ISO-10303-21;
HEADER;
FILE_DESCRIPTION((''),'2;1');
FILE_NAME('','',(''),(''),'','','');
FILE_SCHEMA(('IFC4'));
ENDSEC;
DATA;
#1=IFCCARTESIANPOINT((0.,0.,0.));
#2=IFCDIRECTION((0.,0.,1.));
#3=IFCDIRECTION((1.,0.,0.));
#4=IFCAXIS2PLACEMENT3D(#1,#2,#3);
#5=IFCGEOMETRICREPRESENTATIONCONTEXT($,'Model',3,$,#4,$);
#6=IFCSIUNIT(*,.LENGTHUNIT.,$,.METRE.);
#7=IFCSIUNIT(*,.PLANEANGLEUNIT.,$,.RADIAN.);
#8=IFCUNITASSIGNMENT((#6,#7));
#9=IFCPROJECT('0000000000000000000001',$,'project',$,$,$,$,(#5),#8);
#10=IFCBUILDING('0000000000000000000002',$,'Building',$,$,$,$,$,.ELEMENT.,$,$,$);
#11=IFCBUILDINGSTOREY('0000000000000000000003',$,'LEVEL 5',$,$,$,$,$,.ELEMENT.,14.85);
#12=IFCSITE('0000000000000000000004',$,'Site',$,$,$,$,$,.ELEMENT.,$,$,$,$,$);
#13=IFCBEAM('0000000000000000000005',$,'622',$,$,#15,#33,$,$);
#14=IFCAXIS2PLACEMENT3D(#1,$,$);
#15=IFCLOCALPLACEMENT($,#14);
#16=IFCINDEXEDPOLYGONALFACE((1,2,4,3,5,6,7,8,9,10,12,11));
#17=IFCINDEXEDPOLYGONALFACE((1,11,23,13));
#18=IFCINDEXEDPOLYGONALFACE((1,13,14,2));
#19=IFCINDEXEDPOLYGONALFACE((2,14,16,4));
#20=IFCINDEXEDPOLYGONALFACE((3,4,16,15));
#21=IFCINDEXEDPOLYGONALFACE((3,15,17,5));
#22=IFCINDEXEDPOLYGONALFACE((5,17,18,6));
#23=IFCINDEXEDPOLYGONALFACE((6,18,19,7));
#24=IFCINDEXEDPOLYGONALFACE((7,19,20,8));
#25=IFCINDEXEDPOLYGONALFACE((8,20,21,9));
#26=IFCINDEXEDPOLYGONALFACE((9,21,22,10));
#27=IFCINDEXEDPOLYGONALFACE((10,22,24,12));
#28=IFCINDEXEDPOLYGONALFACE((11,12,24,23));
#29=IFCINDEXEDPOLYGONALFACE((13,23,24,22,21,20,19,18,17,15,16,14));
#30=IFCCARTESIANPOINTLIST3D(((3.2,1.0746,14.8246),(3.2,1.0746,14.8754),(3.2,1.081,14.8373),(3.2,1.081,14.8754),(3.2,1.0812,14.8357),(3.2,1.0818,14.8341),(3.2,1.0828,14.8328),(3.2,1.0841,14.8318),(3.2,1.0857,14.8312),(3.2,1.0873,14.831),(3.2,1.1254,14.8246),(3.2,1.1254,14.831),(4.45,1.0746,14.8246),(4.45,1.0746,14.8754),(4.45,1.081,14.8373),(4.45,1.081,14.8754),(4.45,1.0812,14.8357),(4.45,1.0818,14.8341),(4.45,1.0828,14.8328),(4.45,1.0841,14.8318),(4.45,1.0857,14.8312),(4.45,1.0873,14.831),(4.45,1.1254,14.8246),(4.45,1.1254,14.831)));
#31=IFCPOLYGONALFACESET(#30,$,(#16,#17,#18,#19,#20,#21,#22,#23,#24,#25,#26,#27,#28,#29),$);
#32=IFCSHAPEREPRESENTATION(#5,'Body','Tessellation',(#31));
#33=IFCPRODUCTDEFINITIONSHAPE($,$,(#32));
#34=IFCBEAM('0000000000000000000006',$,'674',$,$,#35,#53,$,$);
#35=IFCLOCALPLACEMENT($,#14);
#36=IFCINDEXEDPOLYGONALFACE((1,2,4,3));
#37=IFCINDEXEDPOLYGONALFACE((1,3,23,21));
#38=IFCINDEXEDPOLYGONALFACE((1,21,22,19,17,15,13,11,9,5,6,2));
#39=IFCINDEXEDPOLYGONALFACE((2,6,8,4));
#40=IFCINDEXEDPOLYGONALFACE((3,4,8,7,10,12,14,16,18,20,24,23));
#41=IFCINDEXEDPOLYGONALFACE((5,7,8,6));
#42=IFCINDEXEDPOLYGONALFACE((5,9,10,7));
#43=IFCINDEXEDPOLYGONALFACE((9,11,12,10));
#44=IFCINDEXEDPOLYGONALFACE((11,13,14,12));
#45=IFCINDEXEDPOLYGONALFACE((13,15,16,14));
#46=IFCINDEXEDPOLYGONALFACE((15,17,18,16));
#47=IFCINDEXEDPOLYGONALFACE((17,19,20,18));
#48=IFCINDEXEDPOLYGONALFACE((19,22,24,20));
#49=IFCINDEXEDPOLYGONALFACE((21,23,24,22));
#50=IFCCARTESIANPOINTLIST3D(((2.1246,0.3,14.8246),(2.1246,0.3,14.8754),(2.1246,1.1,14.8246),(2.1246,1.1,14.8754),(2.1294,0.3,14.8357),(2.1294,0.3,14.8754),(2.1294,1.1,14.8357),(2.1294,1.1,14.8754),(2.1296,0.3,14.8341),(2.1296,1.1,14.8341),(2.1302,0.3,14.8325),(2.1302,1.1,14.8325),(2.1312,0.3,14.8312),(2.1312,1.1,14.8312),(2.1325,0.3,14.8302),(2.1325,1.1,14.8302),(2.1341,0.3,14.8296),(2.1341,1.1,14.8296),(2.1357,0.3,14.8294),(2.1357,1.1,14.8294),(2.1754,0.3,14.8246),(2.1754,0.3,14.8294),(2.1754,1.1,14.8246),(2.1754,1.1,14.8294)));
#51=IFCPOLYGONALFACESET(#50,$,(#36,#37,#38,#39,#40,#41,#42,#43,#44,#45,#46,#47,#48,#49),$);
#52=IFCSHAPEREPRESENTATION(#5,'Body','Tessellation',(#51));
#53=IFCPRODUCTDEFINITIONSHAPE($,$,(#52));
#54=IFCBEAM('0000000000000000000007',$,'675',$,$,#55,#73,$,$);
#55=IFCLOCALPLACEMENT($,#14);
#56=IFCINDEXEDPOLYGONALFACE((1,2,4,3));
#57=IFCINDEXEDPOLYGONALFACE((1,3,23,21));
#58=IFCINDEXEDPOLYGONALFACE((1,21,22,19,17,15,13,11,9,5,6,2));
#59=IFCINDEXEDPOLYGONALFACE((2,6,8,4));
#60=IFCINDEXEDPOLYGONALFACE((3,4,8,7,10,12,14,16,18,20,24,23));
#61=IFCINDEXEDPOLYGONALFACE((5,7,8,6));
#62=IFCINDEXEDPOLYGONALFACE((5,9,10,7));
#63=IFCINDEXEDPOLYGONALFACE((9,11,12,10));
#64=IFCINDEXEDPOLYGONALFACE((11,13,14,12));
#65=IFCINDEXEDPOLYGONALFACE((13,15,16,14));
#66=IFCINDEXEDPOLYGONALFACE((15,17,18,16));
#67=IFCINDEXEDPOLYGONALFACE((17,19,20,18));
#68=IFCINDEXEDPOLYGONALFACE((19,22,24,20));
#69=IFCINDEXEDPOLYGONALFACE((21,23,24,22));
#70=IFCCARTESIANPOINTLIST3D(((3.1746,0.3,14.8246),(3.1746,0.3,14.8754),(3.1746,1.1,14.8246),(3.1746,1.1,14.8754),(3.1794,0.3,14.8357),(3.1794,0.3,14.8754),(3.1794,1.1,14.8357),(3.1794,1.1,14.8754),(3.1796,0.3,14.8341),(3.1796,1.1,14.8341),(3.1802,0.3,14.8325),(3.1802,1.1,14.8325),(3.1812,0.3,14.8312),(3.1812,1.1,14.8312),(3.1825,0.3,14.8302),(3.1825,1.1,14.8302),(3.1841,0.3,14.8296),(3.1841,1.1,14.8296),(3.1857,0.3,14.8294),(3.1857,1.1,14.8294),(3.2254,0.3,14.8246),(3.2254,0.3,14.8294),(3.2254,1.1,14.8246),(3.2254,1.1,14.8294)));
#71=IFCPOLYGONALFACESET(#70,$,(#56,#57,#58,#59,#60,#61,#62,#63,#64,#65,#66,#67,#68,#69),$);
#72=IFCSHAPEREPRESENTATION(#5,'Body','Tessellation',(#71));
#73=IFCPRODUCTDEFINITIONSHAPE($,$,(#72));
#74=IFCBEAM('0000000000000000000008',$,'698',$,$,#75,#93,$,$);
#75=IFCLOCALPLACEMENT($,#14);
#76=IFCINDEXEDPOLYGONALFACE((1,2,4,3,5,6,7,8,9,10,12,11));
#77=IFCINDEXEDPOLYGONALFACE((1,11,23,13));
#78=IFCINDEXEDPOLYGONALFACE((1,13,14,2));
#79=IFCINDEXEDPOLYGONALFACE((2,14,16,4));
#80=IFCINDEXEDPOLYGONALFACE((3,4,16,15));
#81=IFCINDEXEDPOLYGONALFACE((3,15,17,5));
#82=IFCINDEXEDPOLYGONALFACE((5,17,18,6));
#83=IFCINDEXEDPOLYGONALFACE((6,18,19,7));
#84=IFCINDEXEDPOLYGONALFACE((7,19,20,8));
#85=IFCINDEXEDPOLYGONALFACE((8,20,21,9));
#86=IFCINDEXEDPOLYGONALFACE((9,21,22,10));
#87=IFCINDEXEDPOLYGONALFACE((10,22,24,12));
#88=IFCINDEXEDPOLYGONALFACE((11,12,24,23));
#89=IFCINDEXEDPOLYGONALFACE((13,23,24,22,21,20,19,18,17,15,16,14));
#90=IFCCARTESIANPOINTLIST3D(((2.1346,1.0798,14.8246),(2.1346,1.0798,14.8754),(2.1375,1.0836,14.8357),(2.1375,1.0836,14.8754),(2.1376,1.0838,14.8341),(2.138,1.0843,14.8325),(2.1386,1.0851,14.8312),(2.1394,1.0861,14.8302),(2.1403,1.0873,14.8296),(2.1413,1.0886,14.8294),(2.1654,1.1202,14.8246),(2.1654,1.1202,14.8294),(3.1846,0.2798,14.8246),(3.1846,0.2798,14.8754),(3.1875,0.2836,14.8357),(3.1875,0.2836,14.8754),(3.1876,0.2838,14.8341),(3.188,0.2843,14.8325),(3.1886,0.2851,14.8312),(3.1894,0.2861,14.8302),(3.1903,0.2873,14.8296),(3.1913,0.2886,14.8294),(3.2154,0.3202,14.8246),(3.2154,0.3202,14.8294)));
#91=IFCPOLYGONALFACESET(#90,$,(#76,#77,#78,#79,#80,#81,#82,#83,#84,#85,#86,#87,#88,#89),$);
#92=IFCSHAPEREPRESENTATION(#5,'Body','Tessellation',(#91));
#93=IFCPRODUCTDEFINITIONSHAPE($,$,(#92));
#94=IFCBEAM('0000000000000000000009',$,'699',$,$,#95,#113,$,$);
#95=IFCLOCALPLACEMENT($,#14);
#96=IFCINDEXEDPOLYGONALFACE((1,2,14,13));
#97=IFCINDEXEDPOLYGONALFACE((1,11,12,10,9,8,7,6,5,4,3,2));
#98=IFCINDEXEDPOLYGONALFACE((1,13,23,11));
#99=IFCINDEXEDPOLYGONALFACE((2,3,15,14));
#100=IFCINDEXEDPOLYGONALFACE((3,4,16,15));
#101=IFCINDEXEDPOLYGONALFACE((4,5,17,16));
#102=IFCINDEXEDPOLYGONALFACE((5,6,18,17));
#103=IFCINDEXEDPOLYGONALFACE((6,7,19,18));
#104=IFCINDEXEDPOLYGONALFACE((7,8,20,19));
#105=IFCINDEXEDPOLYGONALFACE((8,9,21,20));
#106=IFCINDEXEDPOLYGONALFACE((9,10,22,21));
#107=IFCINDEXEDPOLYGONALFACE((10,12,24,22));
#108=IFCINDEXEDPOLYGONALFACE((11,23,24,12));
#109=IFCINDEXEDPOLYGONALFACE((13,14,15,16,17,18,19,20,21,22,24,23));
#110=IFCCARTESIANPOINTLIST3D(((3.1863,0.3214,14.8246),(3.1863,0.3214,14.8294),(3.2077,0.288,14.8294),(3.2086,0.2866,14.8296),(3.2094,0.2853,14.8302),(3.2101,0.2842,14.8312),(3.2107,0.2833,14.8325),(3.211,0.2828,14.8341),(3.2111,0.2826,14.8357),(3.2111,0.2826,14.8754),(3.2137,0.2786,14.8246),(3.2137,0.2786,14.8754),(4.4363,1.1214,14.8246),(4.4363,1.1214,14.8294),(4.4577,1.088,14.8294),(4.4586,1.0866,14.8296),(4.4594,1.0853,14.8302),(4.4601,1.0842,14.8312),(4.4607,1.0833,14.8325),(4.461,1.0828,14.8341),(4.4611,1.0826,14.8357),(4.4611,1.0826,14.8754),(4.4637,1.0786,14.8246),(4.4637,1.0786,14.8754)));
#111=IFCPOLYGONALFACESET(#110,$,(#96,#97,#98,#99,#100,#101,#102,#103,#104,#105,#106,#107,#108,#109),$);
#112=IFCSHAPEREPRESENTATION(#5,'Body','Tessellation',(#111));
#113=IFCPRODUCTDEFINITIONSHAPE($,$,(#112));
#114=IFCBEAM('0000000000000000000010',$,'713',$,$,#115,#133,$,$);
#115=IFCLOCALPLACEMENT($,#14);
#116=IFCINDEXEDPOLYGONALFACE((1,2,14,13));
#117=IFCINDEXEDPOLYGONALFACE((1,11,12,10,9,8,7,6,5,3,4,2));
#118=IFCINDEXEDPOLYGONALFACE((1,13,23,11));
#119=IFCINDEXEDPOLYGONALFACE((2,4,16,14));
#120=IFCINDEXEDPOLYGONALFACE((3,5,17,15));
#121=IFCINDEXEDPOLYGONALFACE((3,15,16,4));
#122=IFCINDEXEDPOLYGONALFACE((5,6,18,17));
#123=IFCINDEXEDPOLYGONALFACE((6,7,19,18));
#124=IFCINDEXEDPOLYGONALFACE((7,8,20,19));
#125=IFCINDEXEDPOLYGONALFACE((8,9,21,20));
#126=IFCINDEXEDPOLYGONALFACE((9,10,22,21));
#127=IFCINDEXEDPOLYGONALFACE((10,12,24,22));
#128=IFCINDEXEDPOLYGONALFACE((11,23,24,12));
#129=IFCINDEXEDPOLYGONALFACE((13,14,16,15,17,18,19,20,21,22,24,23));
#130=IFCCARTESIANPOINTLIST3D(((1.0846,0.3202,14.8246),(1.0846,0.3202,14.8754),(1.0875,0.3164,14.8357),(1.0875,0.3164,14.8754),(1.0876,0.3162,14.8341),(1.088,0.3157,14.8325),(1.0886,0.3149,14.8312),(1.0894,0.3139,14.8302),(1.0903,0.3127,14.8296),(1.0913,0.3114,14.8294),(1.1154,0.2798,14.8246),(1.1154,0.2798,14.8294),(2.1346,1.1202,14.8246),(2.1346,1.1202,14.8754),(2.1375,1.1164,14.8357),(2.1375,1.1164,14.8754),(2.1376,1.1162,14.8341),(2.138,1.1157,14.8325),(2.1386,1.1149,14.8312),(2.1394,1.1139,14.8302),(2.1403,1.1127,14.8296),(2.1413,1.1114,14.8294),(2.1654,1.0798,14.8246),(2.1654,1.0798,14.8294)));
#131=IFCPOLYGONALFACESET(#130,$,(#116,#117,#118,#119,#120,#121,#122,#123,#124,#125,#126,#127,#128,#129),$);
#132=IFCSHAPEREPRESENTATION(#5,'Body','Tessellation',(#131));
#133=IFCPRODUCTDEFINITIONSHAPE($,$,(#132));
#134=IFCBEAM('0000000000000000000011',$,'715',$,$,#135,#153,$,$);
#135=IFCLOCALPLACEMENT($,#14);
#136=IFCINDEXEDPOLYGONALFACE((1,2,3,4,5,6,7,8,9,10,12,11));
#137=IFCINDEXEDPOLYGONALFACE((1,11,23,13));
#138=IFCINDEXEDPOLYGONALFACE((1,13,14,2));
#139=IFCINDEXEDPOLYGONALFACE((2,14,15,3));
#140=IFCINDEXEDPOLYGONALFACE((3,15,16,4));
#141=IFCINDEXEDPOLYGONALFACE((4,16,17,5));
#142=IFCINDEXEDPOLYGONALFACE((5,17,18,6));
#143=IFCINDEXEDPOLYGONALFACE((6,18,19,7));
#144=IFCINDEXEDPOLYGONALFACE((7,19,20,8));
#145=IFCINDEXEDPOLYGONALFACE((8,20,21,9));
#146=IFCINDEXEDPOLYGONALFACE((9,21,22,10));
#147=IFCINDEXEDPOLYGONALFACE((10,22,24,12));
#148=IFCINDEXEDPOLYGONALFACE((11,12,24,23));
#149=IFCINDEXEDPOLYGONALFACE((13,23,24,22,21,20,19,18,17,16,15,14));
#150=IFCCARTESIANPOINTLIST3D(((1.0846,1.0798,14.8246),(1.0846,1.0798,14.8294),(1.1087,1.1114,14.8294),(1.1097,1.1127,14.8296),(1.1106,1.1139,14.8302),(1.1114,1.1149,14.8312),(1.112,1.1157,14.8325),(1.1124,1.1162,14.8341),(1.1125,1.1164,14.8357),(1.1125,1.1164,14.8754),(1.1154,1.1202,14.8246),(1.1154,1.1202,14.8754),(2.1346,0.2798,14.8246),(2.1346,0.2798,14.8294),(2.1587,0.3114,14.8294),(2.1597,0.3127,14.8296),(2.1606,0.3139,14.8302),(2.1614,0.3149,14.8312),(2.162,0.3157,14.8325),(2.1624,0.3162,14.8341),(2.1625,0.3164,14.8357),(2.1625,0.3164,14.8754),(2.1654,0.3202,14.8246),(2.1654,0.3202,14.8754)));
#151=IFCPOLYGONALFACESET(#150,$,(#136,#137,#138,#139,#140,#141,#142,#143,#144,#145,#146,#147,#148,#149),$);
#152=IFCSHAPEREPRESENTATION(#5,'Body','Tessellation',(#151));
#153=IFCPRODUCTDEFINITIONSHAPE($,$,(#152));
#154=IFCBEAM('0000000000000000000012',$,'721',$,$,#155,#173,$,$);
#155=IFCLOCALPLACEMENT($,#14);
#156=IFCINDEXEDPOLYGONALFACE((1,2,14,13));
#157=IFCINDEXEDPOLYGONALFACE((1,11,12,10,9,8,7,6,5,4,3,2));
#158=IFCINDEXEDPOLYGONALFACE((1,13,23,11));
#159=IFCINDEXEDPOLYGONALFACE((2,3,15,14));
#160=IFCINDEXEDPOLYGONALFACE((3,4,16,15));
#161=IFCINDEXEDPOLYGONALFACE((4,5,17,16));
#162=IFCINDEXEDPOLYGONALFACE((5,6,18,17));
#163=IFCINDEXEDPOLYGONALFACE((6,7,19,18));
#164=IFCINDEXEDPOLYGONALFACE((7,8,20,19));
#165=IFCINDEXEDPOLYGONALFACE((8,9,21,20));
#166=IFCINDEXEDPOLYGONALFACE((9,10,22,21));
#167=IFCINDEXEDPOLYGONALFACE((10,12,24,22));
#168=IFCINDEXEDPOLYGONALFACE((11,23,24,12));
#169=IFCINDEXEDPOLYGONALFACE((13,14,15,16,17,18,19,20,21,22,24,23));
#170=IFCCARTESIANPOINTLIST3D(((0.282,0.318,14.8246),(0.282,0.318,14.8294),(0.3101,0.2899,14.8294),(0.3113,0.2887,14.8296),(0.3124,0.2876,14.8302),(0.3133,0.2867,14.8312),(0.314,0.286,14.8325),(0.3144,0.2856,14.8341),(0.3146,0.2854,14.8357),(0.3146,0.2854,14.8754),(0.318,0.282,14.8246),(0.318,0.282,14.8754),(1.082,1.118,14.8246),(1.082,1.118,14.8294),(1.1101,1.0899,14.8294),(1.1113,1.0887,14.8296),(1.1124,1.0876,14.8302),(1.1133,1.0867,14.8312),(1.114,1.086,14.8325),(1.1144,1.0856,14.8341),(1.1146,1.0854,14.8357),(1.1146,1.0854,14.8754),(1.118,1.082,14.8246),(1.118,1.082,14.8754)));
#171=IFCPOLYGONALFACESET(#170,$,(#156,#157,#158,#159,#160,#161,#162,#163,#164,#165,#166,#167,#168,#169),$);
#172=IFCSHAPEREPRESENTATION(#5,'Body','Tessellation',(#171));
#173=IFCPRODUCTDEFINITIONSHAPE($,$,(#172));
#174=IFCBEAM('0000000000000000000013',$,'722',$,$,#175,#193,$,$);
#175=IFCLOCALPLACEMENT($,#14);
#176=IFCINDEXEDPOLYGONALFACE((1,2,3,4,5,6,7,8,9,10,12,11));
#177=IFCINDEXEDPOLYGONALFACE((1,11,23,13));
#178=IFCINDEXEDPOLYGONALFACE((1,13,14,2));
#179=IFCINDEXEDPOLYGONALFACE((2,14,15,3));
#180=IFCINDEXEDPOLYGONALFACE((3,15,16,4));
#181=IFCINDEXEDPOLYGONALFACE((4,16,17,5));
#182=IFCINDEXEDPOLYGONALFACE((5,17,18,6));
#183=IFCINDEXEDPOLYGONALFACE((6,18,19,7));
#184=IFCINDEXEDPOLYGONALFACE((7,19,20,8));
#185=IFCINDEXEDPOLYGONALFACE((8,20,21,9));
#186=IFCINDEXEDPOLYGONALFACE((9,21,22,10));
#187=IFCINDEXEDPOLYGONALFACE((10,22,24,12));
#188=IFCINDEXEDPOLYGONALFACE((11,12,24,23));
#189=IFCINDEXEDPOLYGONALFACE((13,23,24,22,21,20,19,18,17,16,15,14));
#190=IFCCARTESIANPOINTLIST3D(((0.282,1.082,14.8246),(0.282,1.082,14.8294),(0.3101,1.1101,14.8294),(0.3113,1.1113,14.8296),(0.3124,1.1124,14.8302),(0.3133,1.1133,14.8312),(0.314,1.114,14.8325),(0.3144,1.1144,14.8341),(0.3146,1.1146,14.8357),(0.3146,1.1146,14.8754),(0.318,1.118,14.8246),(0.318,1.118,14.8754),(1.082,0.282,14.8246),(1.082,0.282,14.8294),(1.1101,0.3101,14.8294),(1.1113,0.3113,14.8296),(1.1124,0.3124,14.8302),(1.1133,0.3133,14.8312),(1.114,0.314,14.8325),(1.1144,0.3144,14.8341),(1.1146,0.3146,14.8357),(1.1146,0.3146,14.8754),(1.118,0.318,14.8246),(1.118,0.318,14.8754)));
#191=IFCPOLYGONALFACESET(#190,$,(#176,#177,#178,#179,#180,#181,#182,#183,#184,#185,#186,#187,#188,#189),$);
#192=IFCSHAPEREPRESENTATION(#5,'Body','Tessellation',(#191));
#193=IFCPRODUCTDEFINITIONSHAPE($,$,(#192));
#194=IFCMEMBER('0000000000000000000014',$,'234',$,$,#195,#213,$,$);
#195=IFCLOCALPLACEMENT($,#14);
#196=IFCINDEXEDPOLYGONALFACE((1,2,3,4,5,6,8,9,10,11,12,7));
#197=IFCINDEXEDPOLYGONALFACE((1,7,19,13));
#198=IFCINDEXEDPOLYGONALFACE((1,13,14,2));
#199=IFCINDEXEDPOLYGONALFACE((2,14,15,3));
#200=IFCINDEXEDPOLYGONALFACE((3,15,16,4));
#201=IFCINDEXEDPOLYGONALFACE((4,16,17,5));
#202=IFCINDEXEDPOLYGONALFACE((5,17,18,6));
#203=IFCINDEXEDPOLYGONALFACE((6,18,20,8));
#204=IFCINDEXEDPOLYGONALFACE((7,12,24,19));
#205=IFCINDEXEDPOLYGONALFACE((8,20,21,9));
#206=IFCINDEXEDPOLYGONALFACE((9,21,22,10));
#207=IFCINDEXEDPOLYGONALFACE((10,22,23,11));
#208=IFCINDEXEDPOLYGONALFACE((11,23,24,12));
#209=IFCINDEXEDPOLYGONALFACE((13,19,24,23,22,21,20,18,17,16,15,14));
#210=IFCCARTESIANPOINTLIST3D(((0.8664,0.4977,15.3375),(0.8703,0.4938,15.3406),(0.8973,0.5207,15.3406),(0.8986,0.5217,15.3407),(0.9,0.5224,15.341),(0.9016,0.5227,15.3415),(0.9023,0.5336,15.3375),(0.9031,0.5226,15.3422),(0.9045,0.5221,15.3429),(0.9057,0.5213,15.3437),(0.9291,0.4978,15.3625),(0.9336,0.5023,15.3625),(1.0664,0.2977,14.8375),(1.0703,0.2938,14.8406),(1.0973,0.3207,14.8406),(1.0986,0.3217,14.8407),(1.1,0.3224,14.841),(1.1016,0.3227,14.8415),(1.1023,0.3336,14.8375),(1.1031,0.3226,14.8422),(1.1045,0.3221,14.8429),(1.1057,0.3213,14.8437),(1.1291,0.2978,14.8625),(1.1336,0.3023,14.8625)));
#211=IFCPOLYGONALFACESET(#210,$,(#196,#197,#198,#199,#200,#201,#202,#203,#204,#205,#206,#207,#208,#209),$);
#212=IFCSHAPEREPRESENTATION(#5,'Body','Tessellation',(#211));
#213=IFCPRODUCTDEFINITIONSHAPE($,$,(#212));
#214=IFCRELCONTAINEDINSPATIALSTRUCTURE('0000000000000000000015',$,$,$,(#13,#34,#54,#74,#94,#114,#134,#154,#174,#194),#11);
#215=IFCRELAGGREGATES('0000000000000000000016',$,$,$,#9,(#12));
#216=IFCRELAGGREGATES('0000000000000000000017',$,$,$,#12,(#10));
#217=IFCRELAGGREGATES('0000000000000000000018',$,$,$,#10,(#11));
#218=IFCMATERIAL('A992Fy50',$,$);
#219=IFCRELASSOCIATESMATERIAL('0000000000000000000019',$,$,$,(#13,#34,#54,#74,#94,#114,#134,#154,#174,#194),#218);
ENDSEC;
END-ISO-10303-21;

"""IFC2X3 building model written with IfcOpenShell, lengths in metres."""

from ifc_helpers import new_model, si_unit, frame, origin_with_axes, origin_2d_with_axis, place, context, project, spatial, l_section, extrude, material, element, save


model = new_model("IFC2X3")

# Units and contexts
model_context = context("Model", 3, world=origin_with_axes())
ifc_project = project(units=[si_unit("LENGTHUNIT", "METRE"), si_unit("PLANEANGLEUNIT", "RADIAN")], contexts=[model_context])

# Site, building, storey
site = spatial("IfcSite", under=ifc_project, Name="Site", CompositionType="ELEMENT")
building = spatial("IfcBuilding", under=site, Name="Building", CompositionType="ELEMENT")
storey = spatial("IfcBuildingStorey", under=building, Name="LEVEL 5", CompositionType="ELEMENT", Elevation=14.85)

# Beams
ifc_material = material(Name="A992Fy50")
beam_1_placement = place(None, frame((3.2, 1.1, 14.85), z_axis=(1.0, 0.0, 0.0), x_axis=(0.0, 1.0, 0.0)))
element("IfcBeam", 1, at=beam_1_placement, inside=storey, material=ifc_material, Name="622", context=model_context, shape_type="SweptSolid", body=[
    extrude(l_section(Depth=0.0508, Width=0.0508, Thickness=0.0063, FilletRadius=0.0063, at=origin_2d_with_axis()), origin_with_axes(), (0.0, 0.0, 1.0), 1.25),
])
for number, where, z_axis, x_axis, name in (
    (2, (2.15, 1.1, 14.85), (0.0, -1.0, 0.0), (1.0, 0.0, 0.0), "674"),
    (3, (3.2, 1.1, 14.85), (0.0, -1.0, 0.0), (1.0, 0.0, 0.0), "675"),
):
    element("IfcBeam", number, at=place(None, frame(where, z_axis=z_axis, x_axis=x_axis)), inside=storey, material=ifc_material, Name=name, context=model_context, shape_type="SweptSolid", body=[
        extrude(l_section(Depth=0.0508, Width=0.0508, Thickness=0.0048, FilletRadius=0.0063, at=origin_2d_with_axis()), origin_with_axes(), (0.0, 0.0, 1.0), 0.8),
    ])
beam_2_placement = place(None, frame((2.15, 1.1, 14.85), z_axis=(0.795432, -0.606043, 0.0), x_axis=(0.606043, 0.795432, 0.0)))
element("IfcBeam", 4, at=beam_2_placement, inside=storey, material=ifc_material, Name="698", context=model_context, shape_type="SweptSolid", body=[
    extrude(l_section(Depth=0.0508, Width=0.0508, Thickness=0.0048, FilletRadius=0.0063, at=origin_2d_with_axis()), origin_with_axes(), (0.0, 0.0, 1.0), 1.32),
])
beam_3_placement = place(None, frame((3.2, 0.3, 14.85), z_axis=(0.842271, 0.539054, 0.0), x_axis=(-0.539054, 0.842271, 0.0)))
element("IfcBeam", 5, at=beam_3_placement, inside=storey, material=ifc_material, Name="699", context=model_context, shape_type="SweptSolid", body=[
    extrude(l_section(Depth=0.0508, Width=0.0508, Thickness=0.0048, FilletRadius=0.0063, at=origin_2d_with_axis()), origin_with_axes(), (0.0, 0.0, 1.0), 1.4841),
])
for number, where, z_axis, x_axis, name in (
    (6, (2.15, 1.1, 14.85), (-0.795432, -0.606043, 0.0), (0.606043, -0.795432, 0.0), "713"),
    (7, (2.15, 0.3, 14.85), (-0.795432, 0.606043, 0.0), (-0.606043, -0.795432, 0.0), "715"),
):
    element("IfcBeam", number, at=place(None, frame(where, z_axis=z_axis, x_axis=x_axis)), inside=storey, material=ifc_material, Name=name, context=model_context, shape_type="SweptSolid", body=[
        extrude(l_section(Depth=0.0508, Width=0.0508, Thickness=0.0048, FilletRadius=0.0063, at=origin_2d_with_axis()), origin_with_axes(), (0.0, 0.0, 1.0), 1.32),
    ])
for number, where, z_axis, x_axis, name in (
    (8, (0.3, 0.3, 14.85), (0.707107, 0.707107, 0.0), (-0.707107, 0.707107, 0.0), "721"),
    (9, (1.1, 0.3, 14.85), (-0.707107, 0.707107, 0.0), (-0.707107, -0.707107, 0.0), "722"),
):
    element("IfcBeam", number, at=place(None, frame(where, z_axis=z_axis, x_axis=x_axis)), inside=storey, material=ifc_material, Name=name, context=model_context, shape_type="SweptSolid", body=[
        extrude(l_section(Depth=0.0508, Width=0.0508, Thickness=0.0048, FilletRadius=0.0063, at=origin_2d_with_axis()), origin_with_axes(), (0.0, 0.0, 1.0), 1.1314),
    ])

# Member
for number, where, z_axis, x_axis, name in (
    (10, (1.1, 0.3, 14.85), (-0.348155, 0.348155, 0.870388), (-0.707107, -0.707107, 0.0), "234"),
):
    element("IfcMember", number, at=place(None, frame(where, z_axis=z_axis, x_axis=x_axis)), inside=storey, material=ifc_material, Name=name, context=model_context, shape_type="SweptSolid", body=[
        extrude(l_section(Depth=0.0508, Width=0.0508, Thickness=0.0063, FilletRadius=0.0063, at=origin_2d_with_axis()), origin_with_axes(), (0.0, 0.0, 1.0), 0.5745),
    ])

save(model, "model.ifc")
